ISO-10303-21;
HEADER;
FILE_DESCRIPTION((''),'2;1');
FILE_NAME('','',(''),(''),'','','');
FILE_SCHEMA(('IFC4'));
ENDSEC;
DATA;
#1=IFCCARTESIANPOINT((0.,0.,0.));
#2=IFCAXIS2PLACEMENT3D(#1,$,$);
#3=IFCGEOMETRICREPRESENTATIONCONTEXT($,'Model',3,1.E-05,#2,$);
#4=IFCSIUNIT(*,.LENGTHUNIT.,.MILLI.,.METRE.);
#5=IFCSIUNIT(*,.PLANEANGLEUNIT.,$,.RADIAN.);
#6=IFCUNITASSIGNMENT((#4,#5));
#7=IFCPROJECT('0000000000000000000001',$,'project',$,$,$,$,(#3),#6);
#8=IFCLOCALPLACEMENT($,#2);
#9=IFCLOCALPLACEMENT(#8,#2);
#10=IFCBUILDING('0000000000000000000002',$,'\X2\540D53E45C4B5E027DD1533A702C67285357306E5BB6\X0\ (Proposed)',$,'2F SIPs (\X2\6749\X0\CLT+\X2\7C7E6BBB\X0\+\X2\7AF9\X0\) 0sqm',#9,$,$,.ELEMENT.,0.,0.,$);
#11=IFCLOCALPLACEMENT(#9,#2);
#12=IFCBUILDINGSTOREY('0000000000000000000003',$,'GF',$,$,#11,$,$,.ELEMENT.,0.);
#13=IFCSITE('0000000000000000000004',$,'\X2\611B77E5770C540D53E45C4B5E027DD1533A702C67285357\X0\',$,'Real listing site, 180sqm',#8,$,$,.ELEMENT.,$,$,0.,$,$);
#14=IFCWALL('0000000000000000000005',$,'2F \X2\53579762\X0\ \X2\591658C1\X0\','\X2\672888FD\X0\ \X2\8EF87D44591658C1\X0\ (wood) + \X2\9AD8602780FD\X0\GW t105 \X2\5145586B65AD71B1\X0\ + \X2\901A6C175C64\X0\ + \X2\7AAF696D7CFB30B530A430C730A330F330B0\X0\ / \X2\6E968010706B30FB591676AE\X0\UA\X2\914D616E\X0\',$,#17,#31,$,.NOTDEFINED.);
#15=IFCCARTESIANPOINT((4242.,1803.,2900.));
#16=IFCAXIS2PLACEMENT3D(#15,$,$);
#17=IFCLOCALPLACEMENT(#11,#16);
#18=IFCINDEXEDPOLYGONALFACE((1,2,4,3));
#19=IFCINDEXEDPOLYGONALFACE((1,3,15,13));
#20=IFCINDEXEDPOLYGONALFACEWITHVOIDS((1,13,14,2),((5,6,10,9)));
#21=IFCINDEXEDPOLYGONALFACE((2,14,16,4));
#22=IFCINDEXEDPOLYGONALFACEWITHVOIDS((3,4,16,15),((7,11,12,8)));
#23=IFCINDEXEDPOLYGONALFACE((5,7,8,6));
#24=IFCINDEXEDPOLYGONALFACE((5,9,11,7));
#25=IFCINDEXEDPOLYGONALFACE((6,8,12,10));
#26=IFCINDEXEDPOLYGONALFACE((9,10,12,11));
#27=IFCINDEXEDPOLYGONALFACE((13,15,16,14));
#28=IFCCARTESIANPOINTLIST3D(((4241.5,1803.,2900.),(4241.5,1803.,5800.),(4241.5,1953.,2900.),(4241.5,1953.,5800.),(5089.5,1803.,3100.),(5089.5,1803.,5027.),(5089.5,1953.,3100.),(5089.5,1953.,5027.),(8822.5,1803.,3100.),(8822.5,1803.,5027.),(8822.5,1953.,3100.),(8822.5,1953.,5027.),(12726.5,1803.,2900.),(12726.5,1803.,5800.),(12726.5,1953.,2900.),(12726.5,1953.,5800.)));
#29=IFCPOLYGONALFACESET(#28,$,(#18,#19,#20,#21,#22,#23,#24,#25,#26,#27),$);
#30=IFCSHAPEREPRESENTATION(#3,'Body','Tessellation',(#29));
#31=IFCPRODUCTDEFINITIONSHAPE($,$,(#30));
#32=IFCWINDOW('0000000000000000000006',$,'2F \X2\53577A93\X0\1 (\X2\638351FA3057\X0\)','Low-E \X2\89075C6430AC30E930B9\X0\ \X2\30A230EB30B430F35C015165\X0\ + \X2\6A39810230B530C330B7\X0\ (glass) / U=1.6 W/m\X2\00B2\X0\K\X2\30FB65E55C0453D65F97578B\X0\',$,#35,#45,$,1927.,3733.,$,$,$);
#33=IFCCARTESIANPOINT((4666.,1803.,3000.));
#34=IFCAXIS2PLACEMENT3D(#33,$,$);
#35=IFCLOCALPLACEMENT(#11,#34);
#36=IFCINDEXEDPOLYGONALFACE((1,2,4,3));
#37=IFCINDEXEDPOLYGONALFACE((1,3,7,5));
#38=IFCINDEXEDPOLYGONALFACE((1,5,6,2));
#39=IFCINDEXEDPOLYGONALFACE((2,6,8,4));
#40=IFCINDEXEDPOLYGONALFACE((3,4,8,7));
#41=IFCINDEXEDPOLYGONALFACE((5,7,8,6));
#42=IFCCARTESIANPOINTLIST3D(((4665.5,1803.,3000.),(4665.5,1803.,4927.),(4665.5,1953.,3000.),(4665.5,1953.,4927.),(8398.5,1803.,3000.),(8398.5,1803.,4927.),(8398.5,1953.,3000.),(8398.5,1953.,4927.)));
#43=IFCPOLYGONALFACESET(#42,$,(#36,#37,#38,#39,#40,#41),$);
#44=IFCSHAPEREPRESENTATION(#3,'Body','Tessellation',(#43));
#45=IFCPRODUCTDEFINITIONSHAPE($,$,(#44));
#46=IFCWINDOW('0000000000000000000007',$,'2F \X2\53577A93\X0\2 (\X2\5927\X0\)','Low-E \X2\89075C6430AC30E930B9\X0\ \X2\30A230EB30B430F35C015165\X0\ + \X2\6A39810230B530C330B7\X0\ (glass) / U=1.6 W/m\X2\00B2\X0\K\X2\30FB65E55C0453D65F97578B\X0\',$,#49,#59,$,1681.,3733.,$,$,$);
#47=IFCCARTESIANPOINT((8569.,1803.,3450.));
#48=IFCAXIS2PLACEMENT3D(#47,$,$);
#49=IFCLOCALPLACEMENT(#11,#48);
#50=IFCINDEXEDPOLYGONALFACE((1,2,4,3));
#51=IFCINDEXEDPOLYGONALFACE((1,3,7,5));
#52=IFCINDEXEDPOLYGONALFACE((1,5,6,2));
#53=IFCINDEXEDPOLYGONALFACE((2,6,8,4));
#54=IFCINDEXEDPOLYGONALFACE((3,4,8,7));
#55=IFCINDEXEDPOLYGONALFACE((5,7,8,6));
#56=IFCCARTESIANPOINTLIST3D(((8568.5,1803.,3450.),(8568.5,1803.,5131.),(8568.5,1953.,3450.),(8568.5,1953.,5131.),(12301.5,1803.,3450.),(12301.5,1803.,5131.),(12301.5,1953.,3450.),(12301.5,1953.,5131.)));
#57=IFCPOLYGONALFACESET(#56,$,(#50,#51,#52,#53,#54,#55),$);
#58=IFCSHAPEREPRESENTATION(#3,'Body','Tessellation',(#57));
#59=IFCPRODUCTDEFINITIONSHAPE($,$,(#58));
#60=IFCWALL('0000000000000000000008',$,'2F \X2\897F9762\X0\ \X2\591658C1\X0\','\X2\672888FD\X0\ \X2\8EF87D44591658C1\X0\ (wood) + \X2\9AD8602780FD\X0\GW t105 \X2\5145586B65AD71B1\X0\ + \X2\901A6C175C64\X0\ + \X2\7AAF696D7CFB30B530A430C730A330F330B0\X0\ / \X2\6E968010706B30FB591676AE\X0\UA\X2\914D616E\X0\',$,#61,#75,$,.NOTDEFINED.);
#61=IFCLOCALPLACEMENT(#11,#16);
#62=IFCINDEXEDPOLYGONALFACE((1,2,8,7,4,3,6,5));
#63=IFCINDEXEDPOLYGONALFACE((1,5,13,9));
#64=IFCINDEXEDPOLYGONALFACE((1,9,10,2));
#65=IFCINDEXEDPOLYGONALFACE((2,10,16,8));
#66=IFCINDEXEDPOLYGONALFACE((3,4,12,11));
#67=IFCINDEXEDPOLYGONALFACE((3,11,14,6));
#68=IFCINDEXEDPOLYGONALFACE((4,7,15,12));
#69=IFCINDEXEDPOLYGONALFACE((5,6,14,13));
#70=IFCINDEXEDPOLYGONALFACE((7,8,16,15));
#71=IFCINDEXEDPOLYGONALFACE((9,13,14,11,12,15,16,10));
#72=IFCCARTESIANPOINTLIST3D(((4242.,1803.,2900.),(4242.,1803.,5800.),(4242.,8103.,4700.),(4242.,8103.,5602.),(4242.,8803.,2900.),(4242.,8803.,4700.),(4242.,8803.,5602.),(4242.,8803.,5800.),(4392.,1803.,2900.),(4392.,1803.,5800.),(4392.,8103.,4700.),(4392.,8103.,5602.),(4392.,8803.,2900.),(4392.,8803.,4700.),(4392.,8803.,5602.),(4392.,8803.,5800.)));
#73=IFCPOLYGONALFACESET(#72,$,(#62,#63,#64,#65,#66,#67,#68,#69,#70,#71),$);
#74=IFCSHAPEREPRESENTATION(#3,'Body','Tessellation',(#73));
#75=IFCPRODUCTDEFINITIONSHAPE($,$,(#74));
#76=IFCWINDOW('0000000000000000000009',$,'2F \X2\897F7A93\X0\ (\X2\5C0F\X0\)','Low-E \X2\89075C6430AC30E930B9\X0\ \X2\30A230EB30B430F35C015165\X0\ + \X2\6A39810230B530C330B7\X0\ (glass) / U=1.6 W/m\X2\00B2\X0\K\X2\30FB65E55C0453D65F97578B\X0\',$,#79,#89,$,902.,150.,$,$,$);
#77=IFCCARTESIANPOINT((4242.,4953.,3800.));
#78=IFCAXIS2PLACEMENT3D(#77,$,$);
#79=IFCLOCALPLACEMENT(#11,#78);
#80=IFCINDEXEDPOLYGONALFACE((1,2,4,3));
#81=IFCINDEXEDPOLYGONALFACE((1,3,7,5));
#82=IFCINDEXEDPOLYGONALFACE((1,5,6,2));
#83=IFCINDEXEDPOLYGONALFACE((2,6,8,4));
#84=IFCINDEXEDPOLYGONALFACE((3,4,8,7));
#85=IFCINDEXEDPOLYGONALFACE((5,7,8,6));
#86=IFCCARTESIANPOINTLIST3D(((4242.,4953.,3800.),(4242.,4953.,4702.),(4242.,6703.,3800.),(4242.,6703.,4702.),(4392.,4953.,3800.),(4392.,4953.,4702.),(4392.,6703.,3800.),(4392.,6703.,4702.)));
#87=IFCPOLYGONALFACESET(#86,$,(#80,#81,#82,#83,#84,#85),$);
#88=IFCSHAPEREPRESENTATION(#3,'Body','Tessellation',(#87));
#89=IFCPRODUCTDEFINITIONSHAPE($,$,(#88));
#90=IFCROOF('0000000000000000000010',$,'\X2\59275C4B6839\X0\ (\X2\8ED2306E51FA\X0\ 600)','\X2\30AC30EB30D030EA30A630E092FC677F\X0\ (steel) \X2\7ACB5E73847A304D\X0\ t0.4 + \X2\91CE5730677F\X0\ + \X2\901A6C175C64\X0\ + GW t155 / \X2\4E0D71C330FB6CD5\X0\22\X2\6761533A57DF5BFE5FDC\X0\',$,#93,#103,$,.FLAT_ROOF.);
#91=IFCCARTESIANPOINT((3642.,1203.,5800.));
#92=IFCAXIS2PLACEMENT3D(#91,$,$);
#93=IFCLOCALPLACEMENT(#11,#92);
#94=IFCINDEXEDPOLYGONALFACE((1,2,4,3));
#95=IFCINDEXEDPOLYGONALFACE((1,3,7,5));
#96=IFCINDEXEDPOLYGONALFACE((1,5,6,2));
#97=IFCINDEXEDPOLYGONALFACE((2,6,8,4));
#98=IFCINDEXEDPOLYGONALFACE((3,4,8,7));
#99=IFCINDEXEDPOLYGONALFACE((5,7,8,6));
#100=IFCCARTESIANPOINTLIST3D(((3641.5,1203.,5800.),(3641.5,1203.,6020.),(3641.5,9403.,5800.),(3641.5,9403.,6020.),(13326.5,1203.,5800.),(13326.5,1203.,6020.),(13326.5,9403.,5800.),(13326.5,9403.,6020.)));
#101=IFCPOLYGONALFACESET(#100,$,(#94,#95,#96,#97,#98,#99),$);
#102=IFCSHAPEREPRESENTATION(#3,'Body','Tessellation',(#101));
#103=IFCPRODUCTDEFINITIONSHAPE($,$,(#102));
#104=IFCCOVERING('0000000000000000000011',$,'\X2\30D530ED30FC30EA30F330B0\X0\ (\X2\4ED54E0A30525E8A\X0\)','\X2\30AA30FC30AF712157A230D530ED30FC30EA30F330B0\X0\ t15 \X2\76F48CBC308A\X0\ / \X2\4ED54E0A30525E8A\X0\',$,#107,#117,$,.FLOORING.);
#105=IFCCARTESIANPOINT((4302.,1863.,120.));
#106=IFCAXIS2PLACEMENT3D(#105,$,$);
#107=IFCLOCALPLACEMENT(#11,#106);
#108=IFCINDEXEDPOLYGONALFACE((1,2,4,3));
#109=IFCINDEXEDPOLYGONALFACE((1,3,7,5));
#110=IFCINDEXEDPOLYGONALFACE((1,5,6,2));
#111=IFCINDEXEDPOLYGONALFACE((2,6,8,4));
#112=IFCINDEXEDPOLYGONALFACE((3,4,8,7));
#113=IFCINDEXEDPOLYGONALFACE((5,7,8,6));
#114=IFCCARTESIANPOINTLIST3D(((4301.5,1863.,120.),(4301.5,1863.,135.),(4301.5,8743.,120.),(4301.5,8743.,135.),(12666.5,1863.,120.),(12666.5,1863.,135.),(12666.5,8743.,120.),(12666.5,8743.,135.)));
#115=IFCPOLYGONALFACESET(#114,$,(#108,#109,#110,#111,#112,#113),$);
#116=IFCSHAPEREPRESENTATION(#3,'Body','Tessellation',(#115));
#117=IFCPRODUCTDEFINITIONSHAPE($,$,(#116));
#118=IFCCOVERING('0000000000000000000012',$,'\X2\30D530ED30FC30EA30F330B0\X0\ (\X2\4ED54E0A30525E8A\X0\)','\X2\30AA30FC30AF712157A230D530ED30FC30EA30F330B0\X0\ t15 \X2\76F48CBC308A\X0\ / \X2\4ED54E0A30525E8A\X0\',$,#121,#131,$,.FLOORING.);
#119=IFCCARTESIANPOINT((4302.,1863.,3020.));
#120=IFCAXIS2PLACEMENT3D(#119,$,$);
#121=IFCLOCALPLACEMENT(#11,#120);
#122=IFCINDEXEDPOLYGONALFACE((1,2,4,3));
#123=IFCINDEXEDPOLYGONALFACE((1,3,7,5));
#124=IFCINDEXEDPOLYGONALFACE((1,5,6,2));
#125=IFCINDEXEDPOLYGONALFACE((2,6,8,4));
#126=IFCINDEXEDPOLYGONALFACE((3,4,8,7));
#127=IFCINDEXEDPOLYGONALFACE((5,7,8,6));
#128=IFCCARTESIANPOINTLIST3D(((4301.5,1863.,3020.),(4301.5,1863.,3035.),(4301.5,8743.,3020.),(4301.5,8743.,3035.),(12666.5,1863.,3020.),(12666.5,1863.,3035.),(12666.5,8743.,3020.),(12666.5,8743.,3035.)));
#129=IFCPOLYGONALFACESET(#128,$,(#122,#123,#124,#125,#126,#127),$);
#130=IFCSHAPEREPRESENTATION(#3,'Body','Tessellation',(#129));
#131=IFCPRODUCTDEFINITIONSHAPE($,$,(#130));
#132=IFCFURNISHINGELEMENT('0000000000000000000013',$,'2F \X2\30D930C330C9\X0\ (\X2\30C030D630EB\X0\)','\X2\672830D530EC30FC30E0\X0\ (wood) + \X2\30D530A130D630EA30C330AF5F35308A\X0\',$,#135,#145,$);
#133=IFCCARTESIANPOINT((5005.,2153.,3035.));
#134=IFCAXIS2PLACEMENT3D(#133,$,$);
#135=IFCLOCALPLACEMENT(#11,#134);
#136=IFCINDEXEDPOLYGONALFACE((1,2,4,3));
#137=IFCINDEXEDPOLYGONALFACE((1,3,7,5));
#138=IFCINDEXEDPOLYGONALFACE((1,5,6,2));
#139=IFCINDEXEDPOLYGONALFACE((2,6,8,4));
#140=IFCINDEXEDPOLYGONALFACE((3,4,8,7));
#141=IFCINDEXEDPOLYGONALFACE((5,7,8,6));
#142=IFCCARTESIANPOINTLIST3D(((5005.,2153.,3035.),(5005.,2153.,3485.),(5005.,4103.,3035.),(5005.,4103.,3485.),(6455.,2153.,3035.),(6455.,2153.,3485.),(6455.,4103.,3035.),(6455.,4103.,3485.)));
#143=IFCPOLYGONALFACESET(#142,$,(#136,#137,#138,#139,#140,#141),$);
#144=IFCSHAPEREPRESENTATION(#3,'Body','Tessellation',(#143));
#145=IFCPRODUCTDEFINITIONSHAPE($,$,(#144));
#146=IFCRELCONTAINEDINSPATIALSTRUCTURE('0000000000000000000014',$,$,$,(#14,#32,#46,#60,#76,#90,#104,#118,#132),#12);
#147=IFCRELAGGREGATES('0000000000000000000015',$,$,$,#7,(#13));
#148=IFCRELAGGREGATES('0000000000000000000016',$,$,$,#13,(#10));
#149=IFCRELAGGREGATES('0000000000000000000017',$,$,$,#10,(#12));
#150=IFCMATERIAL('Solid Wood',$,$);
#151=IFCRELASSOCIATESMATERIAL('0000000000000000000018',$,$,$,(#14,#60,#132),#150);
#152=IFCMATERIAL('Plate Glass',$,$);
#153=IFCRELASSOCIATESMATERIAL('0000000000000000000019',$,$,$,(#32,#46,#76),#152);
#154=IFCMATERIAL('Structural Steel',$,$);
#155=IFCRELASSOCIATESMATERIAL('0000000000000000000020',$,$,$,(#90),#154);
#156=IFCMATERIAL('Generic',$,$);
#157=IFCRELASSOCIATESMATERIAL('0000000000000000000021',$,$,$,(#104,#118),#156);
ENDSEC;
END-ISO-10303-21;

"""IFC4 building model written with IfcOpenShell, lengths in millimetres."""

from ifc_helpers import new_model, si_unit, frame, frame_2d, origin, place, context, project, spatial, rectangle, extrude, material, element, fill, save


model = new_model("IFC4")

# Units and contexts
model_context = context("Model", 3, precision=1e-05, world=origin())
ifc_project = project(units=[si_unit("LENGTHUNIT", "METRE", prefix="MILLI"), si_unit("PLANEANGLEUNIT", "RADIAN")], contexts=[model_context])

# Site, building, storey
site_placement = place(None, origin())
site = spatial("IfcSite", under=ifc_project, at=site_placement, Name="愛知県名古屋市緑区瀬木南", ObjectType="Real listing site, 180sqm", CompositionType="ELEMENT", RefElevation=0.0)
building_placement = place(site_placement, origin())
building = spatial("IfcBuilding", under=site, at=building_placement, Name="名古屋市緑区瀬木南の家 (Proposed)", ObjectType="2F SIPs (杉CLT+籾殻+竹) 0sqm", CompositionType="ELEMENT", ElevationOfRefHeight=0.0, ElevationOfTerrain=0.0)
storey_placement = place(building_placement, origin())
storey = spatial("IfcBuildingStorey", under=building, at=storey_placement, Name="GF", CompositionType="ELEMENT", Elevation=0.0)

# Shared definitions
ifc_material_1 = material(Name="Solid Wood")

# Shared definitions
ifc_material_2 = material(Name="Plate Glass")

# Wall, openings, windows
wall_1_placement = place(storey_placement, frame((4242.0, 1803.0, 2900.0)))
wall_1 = element("IfcWall", 1, at=wall_1_placement, inside=storey, material=ifc_material_1, Name="2F 南面 外壁", Description="木製 軸組外壁 (wood) + 高性能GW t105 充填断熱 + 通気層 + 窯業系サイディング / 準耐火・外皮UA配慮", PredefinedType="NOTDEFINED", context=model_context, shape_type="SweptSolid", body=[
    extrude(rectangle(XDim=8485.0, YDim=150.0, at=frame_2d((4242.0, 75.0))), frame((4242.0, 1803.0, 2900.0)), (0.0, 0.0, 1.0), 2900.0),
])
opening_1_placement = place(storey_placement, frame((4666.0, 1803.0, 3000.0)))
opening_1 = element("IfcOpeningElement", 2, at=opening_1_placement, cuts=wall_1, PredefinedType="NOTDEFINED", context=model_context, shape_type="SweptSolid", body=[
    extrude(rectangle(XDim=3733.0, YDim=150.0, at=frame_2d((1866.0, 75.0))), frame((4666.0, 1803.0, 3000.0)), (0.0, 0.0, 1.0), 1927.0),
])
opening_2_placement = place(storey_placement, frame((8569.0, 1803.0, 3450.0)))
opening_2 = element("IfcOpeningElement", 3, at=opening_2_placement, cuts=wall_1, PredefinedType="NOTDEFINED", context=model_context, shape_type="SweptSolid", body=[
    extrude(rectangle(XDim=3733.0, YDim=150.0, at=frame_2d((1866.0, 75.0))), frame((8569.0, 1803.0, 3450.0)), (0.0, 0.0, 1.0), 1681.0),
])
window_1_placement = place(storey_placement, frame((4666.0, 1803.0, 3000.0)))
window_1 = element("IfcWindow", 4, at=window_1_placement, inside=storey, material=ifc_material_2, Name="2F 南窓1 (掃出し)", Description="Low-E 複層ガラス アルゴン封入 + 樹脂サッシ (glass) / U=1.6 W/m²K・日射取得型", OverallHeight=1927.0, OverallWidth=3733.0, context=model_context, shape_type="SweptSolid", body=[
    extrude(rectangle(XDim=3733.0, YDim=150.0, at=frame_2d((1866.0, 75.0))), frame((4666.0, 1803.0, 3000.0)), (0.0, 0.0, 1.0), 1927.0),
])
fill(opening_1, window_1)
window_2_placement = place(storey_placement, frame((8569.0, 1803.0, 3450.0)))
window_2 = element("IfcWindow", 5, at=window_2_placement, inside=storey, material=ifc_material_2, Name="2F 南窓2 (大)", Description="Low-E 複層ガラス アルゴン封入 + 樹脂サッシ (glass) / U=1.6 W/m²K・日射取得型", OverallHeight=1681.0, OverallWidth=3733.0, context=model_context, shape_type="SweptSolid", body=[
    extrude(rectangle(XDim=3733.0, YDim=150.0, at=frame_2d((1866.0, 75.0))), frame((8569.0, 1803.0, 3450.0)), (0.0, 0.0, 1.0), 1681.0),
])
fill(opening_2, window_2)

# Wall, opening, window
wall_2_placement = place(storey_placement, frame((4242.0, 1803.0, 2900.0)))
wall_2 = element("IfcWall", 6, at=wall_2_placement, inside=storey, material=ifc_material_1, Name="2F 西面 外壁", Description="木製 軸組外壁 (wood) + 高性能GW t105 充填断熱 + 通気層 + 窯業系サイディング / 準耐火・外皮UA配慮", PredefinedType="NOTDEFINED", context=model_context, shape_type="SweptSolid", body=[
    extrude(rectangle(XDim=150.0, YDim=7000.0, at=frame_2d((75.0, 3500.0))), frame((4242.0, 1803.0, 2900.0)), (0.0, 0.0, 1.0), 2900.0),
])
opening_3_placement = place(storey_placement, frame((4242.0, 4953.0, 3800.0)))
opening_3 = element("IfcOpeningElement", 7, at=opening_3_placement, cuts=wall_2, PredefinedType="NOTDEFINED", context=model_context, shape_type="SweptSolid", body=[
    extrude(rectangle(XDim=150.0, YDim=1750.0, at=frame_2d((75.0, 875.0))), frame((4242.0, 4953.0, 3800.0)), (0.0, 0.0, 1.0), 902.0),
])
window_3_placement = place(storey_placement, frame((4242.0, 4953.0, 3800.0)))
window_3 = element("IfcWindow", 8, at=window_3_placement, inside=storey, material=ifc_material_2, Name="2F 西窓 (小)", Description="Low-E 複層ガラス アルゴン封入 + 樹脂サッシ (glass) / U=1.6 W/m²K・日射取得型", OverallHeight=902.0, OverallWidth=150.0, context=model_context, shape_type="SweptSolid", body=[
    extrude(rectangle(XDim=150.0, YDim=1750.0, at=frame_2d((75.0, 875.0))), frame((4242.0, 4953.0, 3800.0)), (0.0, 0.0, 1.0), 902.0),
])
fill(opening_3, window_3)

# Roof
ifc_material_3 = material(Name="Structural Steel")
roof_placement = place(storey_placement, frame((3642.0, 1203.0, 5800.0)))
element("IfcRoof", 9, at=roof_placement, inside=storey, material=ifc_material_3, Name="大屋根 (軒の出 600)", Description="ガルバリウム鋼板 (steel) 立平葺き t0.4 + 野地板 + 通気層 + GW t155 / 不燃・法22条区域対応", PredefinedType="FLAT_ROOF", context=model_context, shape_type="SweptSolid", body=[
    extrude(rectangle(XDim=9685.0, YDim=8200.0, at=frame_2d((4842.0, 4100.0))), frame((3642.0, 1203.0, 5800.0)), (0.0, 0.0, 1.0), 220.0),
])

# Coverings
ifc_material_4 = material(Name="Generic")
covering_1_placement = place(storey_placement, frame((4302.0, 1863.0, 120.0)))
element("IfcCovering", 10, at=covering_1_placement, inside=storey, material=ifc_material_4, Name="フローリング (仕上げ床)", Description="オーク無垢フローリング t15 直貼り / 仕上げ床", PredefinedType="FLOORING", context=model_context, shape_type="SweptSolid", body=[
    extrude(rectangle(XDim=8365.0, YDim=6880.0, at=frame_2d((4182.0, 3440.0))), frame((4302.0, 1863.0, 120.0)), (0.0, 0.0, 1.0), 15.0),
])
covering_2_placement = place(storey_placement, frame((4302.0, 1863.0, 3020.0)))
element("IfcCovering", 11, at=covering_2_placement, inside=storey, material=ifc_material_4, Name="フローリング (仕上げ床)", Description="オーク無垢フローリング t15 直貼り / 仕上げ床", PredefinedType="FLOORING", context=model_context, shape_type="SweptSolid", body=[
    extrude(rectangle(XDim=8365.0, YDim=6880.0, at=frame_2d((4182.0, 3440.0))), frame((4302.0, 1863.0, 3020.0)), (0.0, 0.0, 1.0), 15.0),
])

# Furnishing element
furnishing_placement = place(storey_placement, frame((5005.0, 2153.0, 3035.0)))
element("IfcFurnishingElement", 12, at=furnishing_placement, inside=storey, material=ifc_material_1, Name="2F ベッド (ダブル)", Description="木フレーム (wood) + ファブリック張り", context=model_context, shape_type="SweptSolid", body=[
    extrude(rectangle(XDim=1450.0, YDim=1950.0, at=frame_2d((725.0, 975.0))), frame((5005.0, 2153.0, 3035.0)), (0.0, 0.0, 1.0), 450.0),
])

save(model, "model.ifc")
